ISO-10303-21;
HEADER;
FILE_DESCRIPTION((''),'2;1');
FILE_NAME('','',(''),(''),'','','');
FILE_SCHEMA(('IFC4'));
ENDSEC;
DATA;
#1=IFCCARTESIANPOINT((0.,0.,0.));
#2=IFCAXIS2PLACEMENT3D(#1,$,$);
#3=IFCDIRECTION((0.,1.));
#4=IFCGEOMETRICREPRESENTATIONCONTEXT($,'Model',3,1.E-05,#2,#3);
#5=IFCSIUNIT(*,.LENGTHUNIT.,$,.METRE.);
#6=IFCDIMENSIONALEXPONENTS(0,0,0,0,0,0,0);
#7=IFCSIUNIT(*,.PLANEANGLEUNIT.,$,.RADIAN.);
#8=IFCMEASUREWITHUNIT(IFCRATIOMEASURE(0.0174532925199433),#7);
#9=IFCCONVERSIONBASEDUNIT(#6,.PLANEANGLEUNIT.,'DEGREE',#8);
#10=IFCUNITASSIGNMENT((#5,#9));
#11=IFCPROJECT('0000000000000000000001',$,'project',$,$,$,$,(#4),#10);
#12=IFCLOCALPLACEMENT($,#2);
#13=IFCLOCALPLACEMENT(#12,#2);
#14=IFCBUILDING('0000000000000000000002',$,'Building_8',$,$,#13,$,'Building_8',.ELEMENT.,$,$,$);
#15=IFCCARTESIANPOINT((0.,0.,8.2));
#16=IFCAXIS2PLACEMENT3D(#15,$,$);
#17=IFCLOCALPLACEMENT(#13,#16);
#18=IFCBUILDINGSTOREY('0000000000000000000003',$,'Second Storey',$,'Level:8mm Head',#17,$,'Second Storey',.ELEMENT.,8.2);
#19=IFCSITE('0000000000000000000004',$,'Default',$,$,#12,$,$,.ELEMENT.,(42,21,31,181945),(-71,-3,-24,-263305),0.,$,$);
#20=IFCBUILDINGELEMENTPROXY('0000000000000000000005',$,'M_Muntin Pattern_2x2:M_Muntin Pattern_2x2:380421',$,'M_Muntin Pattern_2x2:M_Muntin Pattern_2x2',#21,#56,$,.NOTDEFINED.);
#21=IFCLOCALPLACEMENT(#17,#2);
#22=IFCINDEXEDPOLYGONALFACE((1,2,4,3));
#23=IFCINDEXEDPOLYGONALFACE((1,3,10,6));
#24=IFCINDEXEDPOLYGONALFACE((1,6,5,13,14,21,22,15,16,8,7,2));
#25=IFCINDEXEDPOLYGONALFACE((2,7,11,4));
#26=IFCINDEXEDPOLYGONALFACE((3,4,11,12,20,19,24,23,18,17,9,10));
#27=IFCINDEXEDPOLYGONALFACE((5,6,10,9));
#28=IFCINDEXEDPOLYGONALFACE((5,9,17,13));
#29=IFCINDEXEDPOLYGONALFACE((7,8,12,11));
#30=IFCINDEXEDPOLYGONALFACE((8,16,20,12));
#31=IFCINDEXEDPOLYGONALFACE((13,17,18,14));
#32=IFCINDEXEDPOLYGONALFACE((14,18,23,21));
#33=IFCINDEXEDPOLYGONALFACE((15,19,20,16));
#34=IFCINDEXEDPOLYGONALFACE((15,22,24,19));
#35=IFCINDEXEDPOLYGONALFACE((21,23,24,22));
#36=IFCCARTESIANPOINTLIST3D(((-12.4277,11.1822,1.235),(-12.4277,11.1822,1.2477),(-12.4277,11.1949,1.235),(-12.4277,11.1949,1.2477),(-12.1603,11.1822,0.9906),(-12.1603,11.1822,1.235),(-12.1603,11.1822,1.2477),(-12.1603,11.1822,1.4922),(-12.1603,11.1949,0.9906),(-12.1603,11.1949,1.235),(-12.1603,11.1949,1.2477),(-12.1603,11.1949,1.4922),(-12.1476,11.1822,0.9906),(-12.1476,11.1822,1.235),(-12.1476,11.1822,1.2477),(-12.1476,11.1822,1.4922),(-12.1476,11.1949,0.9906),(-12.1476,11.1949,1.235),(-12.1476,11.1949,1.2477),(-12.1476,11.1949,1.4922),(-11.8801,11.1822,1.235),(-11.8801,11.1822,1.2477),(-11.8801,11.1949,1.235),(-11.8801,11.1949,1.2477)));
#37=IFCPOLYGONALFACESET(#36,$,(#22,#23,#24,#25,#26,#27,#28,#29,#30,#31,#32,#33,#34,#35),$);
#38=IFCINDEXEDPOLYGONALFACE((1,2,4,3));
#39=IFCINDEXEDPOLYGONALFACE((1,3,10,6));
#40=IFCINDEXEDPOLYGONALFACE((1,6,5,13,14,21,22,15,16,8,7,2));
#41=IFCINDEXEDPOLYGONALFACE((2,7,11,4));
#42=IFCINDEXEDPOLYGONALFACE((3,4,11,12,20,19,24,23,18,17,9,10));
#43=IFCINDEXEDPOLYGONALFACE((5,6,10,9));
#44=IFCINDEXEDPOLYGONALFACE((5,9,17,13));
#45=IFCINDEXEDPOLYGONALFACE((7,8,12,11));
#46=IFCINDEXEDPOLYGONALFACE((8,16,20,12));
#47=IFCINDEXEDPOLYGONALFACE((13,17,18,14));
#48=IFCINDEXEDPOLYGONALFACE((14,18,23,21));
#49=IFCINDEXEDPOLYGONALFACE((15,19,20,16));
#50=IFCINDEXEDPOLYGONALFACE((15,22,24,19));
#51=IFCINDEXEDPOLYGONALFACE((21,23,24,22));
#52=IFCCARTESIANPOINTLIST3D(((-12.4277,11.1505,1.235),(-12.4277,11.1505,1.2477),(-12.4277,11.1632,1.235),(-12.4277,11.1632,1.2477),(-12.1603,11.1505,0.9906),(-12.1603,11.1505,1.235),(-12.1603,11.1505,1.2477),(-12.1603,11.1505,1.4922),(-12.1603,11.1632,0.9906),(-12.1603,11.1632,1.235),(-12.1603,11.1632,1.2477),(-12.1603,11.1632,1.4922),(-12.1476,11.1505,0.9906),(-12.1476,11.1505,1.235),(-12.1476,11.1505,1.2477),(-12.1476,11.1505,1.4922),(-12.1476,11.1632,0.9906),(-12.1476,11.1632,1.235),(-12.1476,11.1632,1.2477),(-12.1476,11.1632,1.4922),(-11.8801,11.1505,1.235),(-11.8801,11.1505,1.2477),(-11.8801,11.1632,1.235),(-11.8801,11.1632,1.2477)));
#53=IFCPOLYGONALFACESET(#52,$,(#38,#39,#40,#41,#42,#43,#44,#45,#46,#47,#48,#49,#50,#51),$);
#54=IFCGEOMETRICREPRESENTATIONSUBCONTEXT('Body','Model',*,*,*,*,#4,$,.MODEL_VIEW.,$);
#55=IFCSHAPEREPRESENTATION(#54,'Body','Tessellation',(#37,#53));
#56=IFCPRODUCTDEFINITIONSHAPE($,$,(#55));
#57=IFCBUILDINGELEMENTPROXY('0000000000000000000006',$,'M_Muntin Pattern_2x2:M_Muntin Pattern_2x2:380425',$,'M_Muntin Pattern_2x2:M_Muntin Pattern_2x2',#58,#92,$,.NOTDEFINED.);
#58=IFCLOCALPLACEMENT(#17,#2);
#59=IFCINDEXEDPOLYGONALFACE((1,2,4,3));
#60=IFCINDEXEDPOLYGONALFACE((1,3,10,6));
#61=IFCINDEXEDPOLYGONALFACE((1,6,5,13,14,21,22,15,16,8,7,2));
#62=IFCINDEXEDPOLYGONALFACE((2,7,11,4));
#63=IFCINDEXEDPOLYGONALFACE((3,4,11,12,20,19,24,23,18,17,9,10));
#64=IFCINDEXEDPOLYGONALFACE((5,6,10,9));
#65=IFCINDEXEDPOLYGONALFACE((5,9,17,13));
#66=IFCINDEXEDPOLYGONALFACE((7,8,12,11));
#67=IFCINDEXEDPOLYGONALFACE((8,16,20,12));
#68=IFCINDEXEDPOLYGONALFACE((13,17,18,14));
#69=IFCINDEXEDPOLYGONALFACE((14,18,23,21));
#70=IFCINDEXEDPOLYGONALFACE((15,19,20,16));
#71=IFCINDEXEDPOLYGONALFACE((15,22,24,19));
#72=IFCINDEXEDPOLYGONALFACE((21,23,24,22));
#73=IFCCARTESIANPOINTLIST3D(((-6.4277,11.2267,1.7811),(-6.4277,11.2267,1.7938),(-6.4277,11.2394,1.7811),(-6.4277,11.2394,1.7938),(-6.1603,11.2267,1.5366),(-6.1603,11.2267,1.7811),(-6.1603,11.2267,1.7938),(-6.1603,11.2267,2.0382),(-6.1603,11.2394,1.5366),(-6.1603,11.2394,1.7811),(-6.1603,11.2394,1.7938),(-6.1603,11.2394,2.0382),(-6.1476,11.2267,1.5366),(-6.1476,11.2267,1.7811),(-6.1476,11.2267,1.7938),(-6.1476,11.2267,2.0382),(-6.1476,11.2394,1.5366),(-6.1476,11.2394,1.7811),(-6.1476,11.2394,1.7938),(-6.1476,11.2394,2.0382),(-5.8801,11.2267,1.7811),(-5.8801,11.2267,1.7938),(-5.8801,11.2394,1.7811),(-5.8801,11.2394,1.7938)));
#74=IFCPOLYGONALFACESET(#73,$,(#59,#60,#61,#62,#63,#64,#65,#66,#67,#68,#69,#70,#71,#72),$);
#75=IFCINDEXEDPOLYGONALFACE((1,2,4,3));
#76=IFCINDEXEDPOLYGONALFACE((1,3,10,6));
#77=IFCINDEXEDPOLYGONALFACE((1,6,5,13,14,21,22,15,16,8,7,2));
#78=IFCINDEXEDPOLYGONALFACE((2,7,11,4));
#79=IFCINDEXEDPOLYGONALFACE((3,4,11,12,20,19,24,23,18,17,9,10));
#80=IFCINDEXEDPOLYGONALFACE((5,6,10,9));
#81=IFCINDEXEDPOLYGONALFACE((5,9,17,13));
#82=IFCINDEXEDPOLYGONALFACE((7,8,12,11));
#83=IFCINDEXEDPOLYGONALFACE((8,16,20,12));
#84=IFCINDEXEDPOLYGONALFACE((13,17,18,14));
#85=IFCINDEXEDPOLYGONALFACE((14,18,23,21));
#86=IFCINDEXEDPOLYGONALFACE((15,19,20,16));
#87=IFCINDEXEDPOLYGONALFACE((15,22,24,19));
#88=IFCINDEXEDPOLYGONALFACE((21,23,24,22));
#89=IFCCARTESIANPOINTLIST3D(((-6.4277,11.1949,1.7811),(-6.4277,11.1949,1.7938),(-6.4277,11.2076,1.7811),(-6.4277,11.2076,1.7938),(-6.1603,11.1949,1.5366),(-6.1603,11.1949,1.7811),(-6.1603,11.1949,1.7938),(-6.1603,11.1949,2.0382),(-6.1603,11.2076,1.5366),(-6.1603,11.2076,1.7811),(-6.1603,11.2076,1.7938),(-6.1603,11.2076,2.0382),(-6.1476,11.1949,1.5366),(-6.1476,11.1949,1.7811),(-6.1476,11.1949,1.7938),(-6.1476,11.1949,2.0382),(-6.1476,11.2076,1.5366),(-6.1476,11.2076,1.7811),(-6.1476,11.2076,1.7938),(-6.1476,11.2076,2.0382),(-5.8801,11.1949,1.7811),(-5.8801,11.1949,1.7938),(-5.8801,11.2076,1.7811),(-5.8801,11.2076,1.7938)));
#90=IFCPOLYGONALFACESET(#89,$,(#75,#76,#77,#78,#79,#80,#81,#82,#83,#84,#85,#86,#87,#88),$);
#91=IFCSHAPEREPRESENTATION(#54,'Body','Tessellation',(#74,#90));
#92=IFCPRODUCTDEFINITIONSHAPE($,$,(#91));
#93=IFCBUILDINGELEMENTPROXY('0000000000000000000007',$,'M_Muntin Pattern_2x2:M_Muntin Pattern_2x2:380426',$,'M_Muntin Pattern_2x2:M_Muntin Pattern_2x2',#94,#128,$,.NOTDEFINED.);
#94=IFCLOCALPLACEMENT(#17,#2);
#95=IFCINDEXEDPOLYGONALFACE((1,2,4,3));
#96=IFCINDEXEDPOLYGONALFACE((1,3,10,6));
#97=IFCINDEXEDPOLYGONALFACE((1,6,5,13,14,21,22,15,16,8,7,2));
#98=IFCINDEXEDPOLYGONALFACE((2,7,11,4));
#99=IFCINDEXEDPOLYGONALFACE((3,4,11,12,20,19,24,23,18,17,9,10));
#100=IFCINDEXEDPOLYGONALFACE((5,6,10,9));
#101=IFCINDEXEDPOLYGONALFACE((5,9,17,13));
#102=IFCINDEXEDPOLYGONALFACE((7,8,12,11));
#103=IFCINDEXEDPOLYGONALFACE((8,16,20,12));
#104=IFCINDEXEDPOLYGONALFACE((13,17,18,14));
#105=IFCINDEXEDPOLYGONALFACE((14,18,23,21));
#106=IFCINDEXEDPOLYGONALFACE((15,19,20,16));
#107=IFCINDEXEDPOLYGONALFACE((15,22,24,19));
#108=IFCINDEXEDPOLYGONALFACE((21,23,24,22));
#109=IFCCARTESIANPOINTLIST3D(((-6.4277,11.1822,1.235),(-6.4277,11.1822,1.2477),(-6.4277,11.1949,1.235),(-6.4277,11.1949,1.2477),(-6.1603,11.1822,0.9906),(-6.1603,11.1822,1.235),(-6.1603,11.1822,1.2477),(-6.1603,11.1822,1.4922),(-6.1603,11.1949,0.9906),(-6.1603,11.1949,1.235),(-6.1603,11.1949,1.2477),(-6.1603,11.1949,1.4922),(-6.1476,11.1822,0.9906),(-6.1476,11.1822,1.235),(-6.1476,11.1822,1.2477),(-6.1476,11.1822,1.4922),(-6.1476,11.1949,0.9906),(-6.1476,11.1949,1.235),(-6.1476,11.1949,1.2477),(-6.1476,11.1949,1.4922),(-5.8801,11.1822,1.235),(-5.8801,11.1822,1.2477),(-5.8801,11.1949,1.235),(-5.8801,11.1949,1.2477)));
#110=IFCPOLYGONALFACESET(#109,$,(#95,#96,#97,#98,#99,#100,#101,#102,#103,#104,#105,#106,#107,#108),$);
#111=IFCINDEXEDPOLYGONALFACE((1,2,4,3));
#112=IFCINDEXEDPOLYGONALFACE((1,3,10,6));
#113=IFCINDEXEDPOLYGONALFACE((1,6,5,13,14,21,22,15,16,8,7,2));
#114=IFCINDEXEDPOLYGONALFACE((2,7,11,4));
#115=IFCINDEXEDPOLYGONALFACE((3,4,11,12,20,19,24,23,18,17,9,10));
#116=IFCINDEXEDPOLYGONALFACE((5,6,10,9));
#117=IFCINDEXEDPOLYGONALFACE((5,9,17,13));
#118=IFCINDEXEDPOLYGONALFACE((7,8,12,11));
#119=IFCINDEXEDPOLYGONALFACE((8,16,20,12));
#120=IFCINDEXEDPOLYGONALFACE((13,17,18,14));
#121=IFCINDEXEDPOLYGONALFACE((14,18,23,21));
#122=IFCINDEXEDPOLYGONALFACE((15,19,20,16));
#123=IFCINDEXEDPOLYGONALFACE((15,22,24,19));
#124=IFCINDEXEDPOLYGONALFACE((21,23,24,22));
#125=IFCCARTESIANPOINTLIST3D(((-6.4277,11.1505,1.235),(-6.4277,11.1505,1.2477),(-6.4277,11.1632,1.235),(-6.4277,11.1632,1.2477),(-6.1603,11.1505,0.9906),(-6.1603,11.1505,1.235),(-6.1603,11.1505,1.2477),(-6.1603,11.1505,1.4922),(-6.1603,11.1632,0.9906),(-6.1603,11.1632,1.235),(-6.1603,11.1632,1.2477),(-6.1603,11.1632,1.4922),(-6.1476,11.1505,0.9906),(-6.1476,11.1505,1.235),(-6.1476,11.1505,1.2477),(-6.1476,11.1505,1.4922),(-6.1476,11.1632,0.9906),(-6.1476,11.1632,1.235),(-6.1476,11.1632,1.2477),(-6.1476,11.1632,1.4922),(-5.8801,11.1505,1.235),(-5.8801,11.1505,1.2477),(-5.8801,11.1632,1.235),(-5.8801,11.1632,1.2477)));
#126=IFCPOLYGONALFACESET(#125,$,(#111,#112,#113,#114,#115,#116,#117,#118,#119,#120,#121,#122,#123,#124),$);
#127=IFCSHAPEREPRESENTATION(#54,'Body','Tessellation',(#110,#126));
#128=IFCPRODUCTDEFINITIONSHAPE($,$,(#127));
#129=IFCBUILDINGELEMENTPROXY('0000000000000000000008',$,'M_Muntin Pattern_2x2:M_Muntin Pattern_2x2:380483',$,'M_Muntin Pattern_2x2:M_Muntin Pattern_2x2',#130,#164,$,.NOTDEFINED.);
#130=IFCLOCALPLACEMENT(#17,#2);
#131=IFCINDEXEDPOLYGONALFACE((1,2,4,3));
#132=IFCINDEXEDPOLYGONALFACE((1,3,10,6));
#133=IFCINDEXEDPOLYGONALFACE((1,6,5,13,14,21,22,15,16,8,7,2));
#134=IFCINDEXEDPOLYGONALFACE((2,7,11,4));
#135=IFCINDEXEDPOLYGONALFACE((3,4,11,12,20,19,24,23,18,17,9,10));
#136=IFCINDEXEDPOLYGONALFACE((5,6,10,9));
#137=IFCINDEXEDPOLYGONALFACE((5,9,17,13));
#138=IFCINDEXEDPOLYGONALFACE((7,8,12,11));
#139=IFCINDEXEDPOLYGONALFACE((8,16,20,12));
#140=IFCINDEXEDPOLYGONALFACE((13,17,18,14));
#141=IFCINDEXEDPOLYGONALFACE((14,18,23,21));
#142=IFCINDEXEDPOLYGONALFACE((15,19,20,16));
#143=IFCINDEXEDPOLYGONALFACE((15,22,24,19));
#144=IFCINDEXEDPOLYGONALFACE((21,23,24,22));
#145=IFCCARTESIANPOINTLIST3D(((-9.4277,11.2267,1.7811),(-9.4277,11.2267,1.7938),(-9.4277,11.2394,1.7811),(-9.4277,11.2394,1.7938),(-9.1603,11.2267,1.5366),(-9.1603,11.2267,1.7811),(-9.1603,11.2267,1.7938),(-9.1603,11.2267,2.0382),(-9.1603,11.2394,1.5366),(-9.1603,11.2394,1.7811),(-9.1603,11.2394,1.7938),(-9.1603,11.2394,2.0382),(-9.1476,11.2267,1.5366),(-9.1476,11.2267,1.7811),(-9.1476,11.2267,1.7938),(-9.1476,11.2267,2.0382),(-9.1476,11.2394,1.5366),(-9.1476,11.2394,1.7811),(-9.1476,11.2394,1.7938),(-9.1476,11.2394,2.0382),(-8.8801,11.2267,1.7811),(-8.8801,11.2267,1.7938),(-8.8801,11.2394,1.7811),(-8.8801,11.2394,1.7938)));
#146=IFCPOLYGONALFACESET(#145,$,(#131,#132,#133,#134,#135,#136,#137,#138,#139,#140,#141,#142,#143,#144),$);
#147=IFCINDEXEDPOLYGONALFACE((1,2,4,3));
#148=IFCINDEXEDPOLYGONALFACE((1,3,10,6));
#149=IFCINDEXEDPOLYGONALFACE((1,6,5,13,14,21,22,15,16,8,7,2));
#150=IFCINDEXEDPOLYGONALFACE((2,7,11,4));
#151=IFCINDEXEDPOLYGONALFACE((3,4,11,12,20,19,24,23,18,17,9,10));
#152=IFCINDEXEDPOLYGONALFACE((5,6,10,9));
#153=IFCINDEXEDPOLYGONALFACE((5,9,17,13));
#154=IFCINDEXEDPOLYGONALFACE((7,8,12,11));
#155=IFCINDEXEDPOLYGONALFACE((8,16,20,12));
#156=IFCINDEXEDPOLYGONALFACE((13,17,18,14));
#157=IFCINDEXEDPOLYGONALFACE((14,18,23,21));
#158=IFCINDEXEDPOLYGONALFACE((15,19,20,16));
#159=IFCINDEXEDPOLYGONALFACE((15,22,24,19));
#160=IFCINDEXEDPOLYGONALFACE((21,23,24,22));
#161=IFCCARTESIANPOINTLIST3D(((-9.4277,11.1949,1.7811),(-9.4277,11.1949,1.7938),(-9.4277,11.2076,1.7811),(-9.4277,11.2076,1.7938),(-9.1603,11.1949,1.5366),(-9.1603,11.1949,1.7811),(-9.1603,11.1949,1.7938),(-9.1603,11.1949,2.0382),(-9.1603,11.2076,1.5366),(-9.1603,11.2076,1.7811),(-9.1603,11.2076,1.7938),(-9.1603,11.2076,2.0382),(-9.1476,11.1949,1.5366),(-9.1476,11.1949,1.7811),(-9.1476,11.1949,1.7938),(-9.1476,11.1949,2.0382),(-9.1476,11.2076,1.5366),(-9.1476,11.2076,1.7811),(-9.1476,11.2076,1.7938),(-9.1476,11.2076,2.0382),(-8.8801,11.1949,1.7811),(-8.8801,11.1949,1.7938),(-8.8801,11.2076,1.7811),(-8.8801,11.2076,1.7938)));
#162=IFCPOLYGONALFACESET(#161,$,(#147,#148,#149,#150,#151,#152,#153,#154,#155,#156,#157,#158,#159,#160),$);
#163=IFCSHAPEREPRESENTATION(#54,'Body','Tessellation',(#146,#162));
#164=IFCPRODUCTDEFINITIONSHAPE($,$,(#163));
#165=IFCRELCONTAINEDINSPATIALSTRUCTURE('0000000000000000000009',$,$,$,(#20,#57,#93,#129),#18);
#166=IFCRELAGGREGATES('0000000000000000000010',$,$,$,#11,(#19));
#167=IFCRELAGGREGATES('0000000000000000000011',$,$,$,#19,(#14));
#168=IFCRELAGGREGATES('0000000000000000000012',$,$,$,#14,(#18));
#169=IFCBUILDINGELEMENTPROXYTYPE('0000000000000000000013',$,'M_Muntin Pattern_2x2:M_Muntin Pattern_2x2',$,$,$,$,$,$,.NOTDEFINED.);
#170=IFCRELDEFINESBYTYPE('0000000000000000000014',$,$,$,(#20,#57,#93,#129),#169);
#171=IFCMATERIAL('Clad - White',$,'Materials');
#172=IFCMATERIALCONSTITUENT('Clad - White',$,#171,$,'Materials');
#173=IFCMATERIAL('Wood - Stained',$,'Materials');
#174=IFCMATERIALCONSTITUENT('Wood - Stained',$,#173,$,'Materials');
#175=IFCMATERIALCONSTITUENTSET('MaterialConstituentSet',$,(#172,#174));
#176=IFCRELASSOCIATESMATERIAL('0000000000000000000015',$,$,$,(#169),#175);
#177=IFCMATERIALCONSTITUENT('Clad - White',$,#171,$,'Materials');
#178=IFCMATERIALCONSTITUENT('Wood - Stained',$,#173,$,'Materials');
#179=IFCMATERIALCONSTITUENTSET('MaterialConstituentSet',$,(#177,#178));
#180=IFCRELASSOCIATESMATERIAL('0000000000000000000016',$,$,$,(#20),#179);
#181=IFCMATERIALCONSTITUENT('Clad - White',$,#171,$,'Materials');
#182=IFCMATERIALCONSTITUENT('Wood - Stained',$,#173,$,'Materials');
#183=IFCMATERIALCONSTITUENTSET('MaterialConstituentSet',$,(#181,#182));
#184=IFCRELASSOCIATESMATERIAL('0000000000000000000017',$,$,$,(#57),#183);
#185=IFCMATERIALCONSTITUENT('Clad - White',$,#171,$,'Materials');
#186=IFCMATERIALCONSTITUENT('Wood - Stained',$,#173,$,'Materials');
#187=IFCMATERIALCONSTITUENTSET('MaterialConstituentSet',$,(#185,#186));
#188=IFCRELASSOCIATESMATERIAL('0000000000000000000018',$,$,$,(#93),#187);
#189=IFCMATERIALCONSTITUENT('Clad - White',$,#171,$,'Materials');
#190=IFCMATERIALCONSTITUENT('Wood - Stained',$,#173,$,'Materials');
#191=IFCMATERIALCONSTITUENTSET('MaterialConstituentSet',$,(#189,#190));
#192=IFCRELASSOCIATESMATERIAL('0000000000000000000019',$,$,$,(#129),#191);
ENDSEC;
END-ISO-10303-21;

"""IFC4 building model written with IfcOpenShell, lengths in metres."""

from ifc_helpers import new_model, entity, si_unit, converted_unit, direction, frame, origin, place, context, subcontext, project, spatial, indexed_curve, outline, extrude, source, transform, mapped, material, constituent, constituent_set, type_object, type_shapes, element, save


model = new_model("IFC4")

# Units and contexts
model_context = context("Model", 3, precision=1e-05, world=origin(), true_north=direction((0.0, 1.0)))
body_context = subcontext(model_context, "Body", "Model", "MODEL_VIEW")
ifc_project = project(units=[si_unit("LENGTHUNIT", "METRE"), converted_unit("PLANEANGLEUNIT", "DEGREE", entity("IfcRatioMeasure", 0.0174532925199433), si_unit("PLANEANGLEUNIT", "RADIAN"), dimensions=[0, 0, 0, 0, 0, 0, 0])], contexts=[model_context])

# Site, building, storey
site_placement = place(None, origin())
site = spatial("IfcSite", under=ifc_project, at=site_placement, Name="Default", CompositionType="ELEMENT", RefLatitude=(42, 21, 31, 181945), RefLongitude=(-71, -3, -24, -263305), RefElevation=0.0)
building_placement = place(site_placement, origin())
building = spatial("IfcBuilding", under=site, at=building_placement, Name="Building_8", LongName="Building_8", CompositionType="ELEMENT")
storey_placement = place(building_placement, frame((0.0, 0.0, 8.2)))
storey = spatial("IfcBuildingStorey", under=building, at=storey_placement, Name="Second Storey", ObjectType="Level:8mm Head", LongName="Second Storey", CompositionType="ELEMENT", Elevation=8.2)

# Building element proxies
ifc_material_1 = material(Name="Clad - White", Category="Materials")
ifc_material_2 = material(Name="Wood - Stained", Category="Materials")
ifc_constituent_1 = constituent(ifc_material_1, Name="Clad - White", Category="Materials")
ifc_constituent_2 = constituent(ifc_material_2, Name="Wood - Stained", Category="Materials")
ifc_constituent_set_1 = constituent_set(constituents=[ifc_constituent_1, ifc_constituent_2], Name="MaterialConstituentSet")
building_element_proxy_type_1 = type_object("IfcBuildingElementProxyType", Name="M_Muntin Pattern_2x2:M_Muntin Pattern_2x2", PredefinedType="NOTDEFINED", material=ifc_constituent_set_1)
shared_shape_1 = source(origin(), body_context, "Body", "SweptSolid", [
    extrude(outline(indexed_curve([(0.0064, -0.0064), (0.2508, -0.0064), (0.2508, 0.0063), (0.0064, 0.0063), (0.0064, 0.2738), (-0.0063, 0.2738), (-0.0063, 0.0063), (-0.2508, 0.0063), (-0.2508, -0.0064), (-0.0063, -0.0064), (-0.0063, -0.2738), (0.0064, -0.2738), (0.0064, -0.0064)], self_intersect=False)), frame((0.0, -0.0222, 0.2508), z_axis=(0.0, 1.0, 0.0), x_axis=(0.0, 0.0, 1.0)), (0.0, 0.0, 1.0), 0.0127),
    extrude(outline(indexed_curve([(0.0064, -0.0064), (0.2508, -0.0064), (0.2508, 0.0063), (0.0064, 0.0063), (0.0064, 0.2738), (-0.0063, 0.2738), (-0.0063, 0.0063), (-0.2508, 0.0063), (-0.2508, -0.0064), (-0.0063, -0.0064), (-0.0063, -0.2738), (0.0064, -0.2738), (0.0064, -0.0064)], self_intersect=False)), frame((0.0, 0.0095, 0.2508), z_axis=(0.0, 1.0, 0.0), x_axis=(0.0, 0.0, 1.0)), (0.0, 0.0, 1.0), 0.0127),
])
type_shapes(building_element_proxy_type_1, [shared_shape_1])
ifc_constituent_3 = constituent(ifc_material_1, Name="Clad - White", Category="Materials")
ifc_constituent_4 = constituent(ifc_material_2, Name="Wood - Stained", Category="Materials")
ifc_constituent_set_2 = constituent_set(constituents=[ifc_constituent_3, ifc_constituent_4], Name="MaterialConstituentSet")
proxy_1_placement = place(storey_placement, frame((-12.1539, 11.1727, 0.9906), z_axis=(0.0, 0.0, 1.0), x_axis=(-1.0, 0.0, 0.0)))
element("IfcBuildingElementProxy", 1, at=proxy_1_placement, inside=storey, type_object=building_element_proxy_type_1, material=ifc_constituent_set_2, Name="M_Muntin Pattern_2x2:M_Muntin Pattern_2x2:380421", ObjectType="M_Muntin Pattern_2x2:M_Muntin Pattern_2x2", PredefinedType="NOTDEFINED", context=body_context, shape_type="MappedRepresentation", body=[
    mapped(shared_shape_1, transform((0.0, 0.0, 0.0), scale=1.0)),
])
ifc_constituent_5 = constituent(ifc_material_1, Name="Clad - White", Category="Materials")
ifc_constituent_6 = constituent(ifc_material_2, Name="Wood - Stained", Category="Materials")
ifc_constituent_set_3 = constituent_set(constituents=[ifc_constituent_5, ifc_constituent_6], Name="MaterialConstituentSet")
proxy_2_placement = place(storey_placement, frame((-6.1539, 11.2171, 1.5366), z_axis=(0.0, 0.0, 1.0), x_axis=(-1.0, 0.0, 0.0)))
element("IfcBuildingElementProxy", 2, at=proxy_2_placement, inside=storey, type_object=building_element_proxy_type_1, material=ifc_constituent_set_3, Name="M_Muntin Pattern_2x2:M_Muntin Pattern_2x2:380425", ObjectType="M_Muntin Pattern_2x2:M_Muntin Pattern_2x2", PredefinedType="NOTDEFINED", context=body_context, shape_type="MappedRepresentation", body=[
    mapped(shared_shape_1, transform((0.0, 0.0, 0.0), scale=1.0)),
])
ifc_constituent_7 = constituent(ifc_material_1, Name="Clad - White", Category="Materials")
ifc_constituent_8 = constituent(ifc_material_2, Name="Wood - Stained", Category="Materials")
ifc_constituent_set_4 = constituent_set(constituents=[ifc_constituent_7, ifc_constituent_8], Name="MaterialConstituentSet")
proxy_3_placement = place(storey_placement, frame((-6.1539, 11.1727, 0.9906), z_axis=(0.0, 0.0, 1.0), x_axis=(-1.0, 0.0, 0.0)))
element("IfcBuildingElementProxy", 3, at=proxy_3_placement, inside=storey, type_object=building_element_proxy_type_1, material=ifc_constituent_set_4, Name="M_Muntin Pattern_2x2:M_Muntin Pattern_2x2:380426", ObjectType="M_Muntin Pattern_2x2:M_Muntin Pattern_2x2", PredefinedType="NOTDEFINED", context=body_context, shape_type="MappedRepresentation", body=[
    mapped(shared_shape_1, transform((0.0, 0.0, 0.0), scale=1.0)),
])
ifc_constituent_9 = constituent(ifc_material_1, Name="Clad - White", Category="Materials")
ifc_constituent_10 = constituent(ifc_material_2, Name="Wood - Stained", Category="Materials")
ifc_constituent_set_5 = constituent_set(constituents=[ifc_constituent_9, ifc_constituent_10], Name="MaterialConstituentSet")
proxy_4_placement = place(storey_placement, frame((-9.1539, 11.2171, 1.5366), z_axis=(0.0, 0.0, 1.0), x_axis=(-1.0, 0.0, 0.0)))
element("IfcBuildingElementProxy", 4, at=proxy_4_placement, inside=storey, type_object=building_element_proxy_type_1, material=ifc_constituent_set_5, Name="M_Muntin Pattern_2x2:M_Muntin Pattern_2x2:380483", ObjectType="M_Muntin Pattern_2x2:M_Muntin Pattern_2x2", PredefinedType="NOTDEFINED", context=body_context, shape_type="MappedRepresentation", body=[
    mapped(shared_shape_1, transform((0.0, 0.0, 0.0), scale=1.0)),
])

save(model, "model.ifc")
